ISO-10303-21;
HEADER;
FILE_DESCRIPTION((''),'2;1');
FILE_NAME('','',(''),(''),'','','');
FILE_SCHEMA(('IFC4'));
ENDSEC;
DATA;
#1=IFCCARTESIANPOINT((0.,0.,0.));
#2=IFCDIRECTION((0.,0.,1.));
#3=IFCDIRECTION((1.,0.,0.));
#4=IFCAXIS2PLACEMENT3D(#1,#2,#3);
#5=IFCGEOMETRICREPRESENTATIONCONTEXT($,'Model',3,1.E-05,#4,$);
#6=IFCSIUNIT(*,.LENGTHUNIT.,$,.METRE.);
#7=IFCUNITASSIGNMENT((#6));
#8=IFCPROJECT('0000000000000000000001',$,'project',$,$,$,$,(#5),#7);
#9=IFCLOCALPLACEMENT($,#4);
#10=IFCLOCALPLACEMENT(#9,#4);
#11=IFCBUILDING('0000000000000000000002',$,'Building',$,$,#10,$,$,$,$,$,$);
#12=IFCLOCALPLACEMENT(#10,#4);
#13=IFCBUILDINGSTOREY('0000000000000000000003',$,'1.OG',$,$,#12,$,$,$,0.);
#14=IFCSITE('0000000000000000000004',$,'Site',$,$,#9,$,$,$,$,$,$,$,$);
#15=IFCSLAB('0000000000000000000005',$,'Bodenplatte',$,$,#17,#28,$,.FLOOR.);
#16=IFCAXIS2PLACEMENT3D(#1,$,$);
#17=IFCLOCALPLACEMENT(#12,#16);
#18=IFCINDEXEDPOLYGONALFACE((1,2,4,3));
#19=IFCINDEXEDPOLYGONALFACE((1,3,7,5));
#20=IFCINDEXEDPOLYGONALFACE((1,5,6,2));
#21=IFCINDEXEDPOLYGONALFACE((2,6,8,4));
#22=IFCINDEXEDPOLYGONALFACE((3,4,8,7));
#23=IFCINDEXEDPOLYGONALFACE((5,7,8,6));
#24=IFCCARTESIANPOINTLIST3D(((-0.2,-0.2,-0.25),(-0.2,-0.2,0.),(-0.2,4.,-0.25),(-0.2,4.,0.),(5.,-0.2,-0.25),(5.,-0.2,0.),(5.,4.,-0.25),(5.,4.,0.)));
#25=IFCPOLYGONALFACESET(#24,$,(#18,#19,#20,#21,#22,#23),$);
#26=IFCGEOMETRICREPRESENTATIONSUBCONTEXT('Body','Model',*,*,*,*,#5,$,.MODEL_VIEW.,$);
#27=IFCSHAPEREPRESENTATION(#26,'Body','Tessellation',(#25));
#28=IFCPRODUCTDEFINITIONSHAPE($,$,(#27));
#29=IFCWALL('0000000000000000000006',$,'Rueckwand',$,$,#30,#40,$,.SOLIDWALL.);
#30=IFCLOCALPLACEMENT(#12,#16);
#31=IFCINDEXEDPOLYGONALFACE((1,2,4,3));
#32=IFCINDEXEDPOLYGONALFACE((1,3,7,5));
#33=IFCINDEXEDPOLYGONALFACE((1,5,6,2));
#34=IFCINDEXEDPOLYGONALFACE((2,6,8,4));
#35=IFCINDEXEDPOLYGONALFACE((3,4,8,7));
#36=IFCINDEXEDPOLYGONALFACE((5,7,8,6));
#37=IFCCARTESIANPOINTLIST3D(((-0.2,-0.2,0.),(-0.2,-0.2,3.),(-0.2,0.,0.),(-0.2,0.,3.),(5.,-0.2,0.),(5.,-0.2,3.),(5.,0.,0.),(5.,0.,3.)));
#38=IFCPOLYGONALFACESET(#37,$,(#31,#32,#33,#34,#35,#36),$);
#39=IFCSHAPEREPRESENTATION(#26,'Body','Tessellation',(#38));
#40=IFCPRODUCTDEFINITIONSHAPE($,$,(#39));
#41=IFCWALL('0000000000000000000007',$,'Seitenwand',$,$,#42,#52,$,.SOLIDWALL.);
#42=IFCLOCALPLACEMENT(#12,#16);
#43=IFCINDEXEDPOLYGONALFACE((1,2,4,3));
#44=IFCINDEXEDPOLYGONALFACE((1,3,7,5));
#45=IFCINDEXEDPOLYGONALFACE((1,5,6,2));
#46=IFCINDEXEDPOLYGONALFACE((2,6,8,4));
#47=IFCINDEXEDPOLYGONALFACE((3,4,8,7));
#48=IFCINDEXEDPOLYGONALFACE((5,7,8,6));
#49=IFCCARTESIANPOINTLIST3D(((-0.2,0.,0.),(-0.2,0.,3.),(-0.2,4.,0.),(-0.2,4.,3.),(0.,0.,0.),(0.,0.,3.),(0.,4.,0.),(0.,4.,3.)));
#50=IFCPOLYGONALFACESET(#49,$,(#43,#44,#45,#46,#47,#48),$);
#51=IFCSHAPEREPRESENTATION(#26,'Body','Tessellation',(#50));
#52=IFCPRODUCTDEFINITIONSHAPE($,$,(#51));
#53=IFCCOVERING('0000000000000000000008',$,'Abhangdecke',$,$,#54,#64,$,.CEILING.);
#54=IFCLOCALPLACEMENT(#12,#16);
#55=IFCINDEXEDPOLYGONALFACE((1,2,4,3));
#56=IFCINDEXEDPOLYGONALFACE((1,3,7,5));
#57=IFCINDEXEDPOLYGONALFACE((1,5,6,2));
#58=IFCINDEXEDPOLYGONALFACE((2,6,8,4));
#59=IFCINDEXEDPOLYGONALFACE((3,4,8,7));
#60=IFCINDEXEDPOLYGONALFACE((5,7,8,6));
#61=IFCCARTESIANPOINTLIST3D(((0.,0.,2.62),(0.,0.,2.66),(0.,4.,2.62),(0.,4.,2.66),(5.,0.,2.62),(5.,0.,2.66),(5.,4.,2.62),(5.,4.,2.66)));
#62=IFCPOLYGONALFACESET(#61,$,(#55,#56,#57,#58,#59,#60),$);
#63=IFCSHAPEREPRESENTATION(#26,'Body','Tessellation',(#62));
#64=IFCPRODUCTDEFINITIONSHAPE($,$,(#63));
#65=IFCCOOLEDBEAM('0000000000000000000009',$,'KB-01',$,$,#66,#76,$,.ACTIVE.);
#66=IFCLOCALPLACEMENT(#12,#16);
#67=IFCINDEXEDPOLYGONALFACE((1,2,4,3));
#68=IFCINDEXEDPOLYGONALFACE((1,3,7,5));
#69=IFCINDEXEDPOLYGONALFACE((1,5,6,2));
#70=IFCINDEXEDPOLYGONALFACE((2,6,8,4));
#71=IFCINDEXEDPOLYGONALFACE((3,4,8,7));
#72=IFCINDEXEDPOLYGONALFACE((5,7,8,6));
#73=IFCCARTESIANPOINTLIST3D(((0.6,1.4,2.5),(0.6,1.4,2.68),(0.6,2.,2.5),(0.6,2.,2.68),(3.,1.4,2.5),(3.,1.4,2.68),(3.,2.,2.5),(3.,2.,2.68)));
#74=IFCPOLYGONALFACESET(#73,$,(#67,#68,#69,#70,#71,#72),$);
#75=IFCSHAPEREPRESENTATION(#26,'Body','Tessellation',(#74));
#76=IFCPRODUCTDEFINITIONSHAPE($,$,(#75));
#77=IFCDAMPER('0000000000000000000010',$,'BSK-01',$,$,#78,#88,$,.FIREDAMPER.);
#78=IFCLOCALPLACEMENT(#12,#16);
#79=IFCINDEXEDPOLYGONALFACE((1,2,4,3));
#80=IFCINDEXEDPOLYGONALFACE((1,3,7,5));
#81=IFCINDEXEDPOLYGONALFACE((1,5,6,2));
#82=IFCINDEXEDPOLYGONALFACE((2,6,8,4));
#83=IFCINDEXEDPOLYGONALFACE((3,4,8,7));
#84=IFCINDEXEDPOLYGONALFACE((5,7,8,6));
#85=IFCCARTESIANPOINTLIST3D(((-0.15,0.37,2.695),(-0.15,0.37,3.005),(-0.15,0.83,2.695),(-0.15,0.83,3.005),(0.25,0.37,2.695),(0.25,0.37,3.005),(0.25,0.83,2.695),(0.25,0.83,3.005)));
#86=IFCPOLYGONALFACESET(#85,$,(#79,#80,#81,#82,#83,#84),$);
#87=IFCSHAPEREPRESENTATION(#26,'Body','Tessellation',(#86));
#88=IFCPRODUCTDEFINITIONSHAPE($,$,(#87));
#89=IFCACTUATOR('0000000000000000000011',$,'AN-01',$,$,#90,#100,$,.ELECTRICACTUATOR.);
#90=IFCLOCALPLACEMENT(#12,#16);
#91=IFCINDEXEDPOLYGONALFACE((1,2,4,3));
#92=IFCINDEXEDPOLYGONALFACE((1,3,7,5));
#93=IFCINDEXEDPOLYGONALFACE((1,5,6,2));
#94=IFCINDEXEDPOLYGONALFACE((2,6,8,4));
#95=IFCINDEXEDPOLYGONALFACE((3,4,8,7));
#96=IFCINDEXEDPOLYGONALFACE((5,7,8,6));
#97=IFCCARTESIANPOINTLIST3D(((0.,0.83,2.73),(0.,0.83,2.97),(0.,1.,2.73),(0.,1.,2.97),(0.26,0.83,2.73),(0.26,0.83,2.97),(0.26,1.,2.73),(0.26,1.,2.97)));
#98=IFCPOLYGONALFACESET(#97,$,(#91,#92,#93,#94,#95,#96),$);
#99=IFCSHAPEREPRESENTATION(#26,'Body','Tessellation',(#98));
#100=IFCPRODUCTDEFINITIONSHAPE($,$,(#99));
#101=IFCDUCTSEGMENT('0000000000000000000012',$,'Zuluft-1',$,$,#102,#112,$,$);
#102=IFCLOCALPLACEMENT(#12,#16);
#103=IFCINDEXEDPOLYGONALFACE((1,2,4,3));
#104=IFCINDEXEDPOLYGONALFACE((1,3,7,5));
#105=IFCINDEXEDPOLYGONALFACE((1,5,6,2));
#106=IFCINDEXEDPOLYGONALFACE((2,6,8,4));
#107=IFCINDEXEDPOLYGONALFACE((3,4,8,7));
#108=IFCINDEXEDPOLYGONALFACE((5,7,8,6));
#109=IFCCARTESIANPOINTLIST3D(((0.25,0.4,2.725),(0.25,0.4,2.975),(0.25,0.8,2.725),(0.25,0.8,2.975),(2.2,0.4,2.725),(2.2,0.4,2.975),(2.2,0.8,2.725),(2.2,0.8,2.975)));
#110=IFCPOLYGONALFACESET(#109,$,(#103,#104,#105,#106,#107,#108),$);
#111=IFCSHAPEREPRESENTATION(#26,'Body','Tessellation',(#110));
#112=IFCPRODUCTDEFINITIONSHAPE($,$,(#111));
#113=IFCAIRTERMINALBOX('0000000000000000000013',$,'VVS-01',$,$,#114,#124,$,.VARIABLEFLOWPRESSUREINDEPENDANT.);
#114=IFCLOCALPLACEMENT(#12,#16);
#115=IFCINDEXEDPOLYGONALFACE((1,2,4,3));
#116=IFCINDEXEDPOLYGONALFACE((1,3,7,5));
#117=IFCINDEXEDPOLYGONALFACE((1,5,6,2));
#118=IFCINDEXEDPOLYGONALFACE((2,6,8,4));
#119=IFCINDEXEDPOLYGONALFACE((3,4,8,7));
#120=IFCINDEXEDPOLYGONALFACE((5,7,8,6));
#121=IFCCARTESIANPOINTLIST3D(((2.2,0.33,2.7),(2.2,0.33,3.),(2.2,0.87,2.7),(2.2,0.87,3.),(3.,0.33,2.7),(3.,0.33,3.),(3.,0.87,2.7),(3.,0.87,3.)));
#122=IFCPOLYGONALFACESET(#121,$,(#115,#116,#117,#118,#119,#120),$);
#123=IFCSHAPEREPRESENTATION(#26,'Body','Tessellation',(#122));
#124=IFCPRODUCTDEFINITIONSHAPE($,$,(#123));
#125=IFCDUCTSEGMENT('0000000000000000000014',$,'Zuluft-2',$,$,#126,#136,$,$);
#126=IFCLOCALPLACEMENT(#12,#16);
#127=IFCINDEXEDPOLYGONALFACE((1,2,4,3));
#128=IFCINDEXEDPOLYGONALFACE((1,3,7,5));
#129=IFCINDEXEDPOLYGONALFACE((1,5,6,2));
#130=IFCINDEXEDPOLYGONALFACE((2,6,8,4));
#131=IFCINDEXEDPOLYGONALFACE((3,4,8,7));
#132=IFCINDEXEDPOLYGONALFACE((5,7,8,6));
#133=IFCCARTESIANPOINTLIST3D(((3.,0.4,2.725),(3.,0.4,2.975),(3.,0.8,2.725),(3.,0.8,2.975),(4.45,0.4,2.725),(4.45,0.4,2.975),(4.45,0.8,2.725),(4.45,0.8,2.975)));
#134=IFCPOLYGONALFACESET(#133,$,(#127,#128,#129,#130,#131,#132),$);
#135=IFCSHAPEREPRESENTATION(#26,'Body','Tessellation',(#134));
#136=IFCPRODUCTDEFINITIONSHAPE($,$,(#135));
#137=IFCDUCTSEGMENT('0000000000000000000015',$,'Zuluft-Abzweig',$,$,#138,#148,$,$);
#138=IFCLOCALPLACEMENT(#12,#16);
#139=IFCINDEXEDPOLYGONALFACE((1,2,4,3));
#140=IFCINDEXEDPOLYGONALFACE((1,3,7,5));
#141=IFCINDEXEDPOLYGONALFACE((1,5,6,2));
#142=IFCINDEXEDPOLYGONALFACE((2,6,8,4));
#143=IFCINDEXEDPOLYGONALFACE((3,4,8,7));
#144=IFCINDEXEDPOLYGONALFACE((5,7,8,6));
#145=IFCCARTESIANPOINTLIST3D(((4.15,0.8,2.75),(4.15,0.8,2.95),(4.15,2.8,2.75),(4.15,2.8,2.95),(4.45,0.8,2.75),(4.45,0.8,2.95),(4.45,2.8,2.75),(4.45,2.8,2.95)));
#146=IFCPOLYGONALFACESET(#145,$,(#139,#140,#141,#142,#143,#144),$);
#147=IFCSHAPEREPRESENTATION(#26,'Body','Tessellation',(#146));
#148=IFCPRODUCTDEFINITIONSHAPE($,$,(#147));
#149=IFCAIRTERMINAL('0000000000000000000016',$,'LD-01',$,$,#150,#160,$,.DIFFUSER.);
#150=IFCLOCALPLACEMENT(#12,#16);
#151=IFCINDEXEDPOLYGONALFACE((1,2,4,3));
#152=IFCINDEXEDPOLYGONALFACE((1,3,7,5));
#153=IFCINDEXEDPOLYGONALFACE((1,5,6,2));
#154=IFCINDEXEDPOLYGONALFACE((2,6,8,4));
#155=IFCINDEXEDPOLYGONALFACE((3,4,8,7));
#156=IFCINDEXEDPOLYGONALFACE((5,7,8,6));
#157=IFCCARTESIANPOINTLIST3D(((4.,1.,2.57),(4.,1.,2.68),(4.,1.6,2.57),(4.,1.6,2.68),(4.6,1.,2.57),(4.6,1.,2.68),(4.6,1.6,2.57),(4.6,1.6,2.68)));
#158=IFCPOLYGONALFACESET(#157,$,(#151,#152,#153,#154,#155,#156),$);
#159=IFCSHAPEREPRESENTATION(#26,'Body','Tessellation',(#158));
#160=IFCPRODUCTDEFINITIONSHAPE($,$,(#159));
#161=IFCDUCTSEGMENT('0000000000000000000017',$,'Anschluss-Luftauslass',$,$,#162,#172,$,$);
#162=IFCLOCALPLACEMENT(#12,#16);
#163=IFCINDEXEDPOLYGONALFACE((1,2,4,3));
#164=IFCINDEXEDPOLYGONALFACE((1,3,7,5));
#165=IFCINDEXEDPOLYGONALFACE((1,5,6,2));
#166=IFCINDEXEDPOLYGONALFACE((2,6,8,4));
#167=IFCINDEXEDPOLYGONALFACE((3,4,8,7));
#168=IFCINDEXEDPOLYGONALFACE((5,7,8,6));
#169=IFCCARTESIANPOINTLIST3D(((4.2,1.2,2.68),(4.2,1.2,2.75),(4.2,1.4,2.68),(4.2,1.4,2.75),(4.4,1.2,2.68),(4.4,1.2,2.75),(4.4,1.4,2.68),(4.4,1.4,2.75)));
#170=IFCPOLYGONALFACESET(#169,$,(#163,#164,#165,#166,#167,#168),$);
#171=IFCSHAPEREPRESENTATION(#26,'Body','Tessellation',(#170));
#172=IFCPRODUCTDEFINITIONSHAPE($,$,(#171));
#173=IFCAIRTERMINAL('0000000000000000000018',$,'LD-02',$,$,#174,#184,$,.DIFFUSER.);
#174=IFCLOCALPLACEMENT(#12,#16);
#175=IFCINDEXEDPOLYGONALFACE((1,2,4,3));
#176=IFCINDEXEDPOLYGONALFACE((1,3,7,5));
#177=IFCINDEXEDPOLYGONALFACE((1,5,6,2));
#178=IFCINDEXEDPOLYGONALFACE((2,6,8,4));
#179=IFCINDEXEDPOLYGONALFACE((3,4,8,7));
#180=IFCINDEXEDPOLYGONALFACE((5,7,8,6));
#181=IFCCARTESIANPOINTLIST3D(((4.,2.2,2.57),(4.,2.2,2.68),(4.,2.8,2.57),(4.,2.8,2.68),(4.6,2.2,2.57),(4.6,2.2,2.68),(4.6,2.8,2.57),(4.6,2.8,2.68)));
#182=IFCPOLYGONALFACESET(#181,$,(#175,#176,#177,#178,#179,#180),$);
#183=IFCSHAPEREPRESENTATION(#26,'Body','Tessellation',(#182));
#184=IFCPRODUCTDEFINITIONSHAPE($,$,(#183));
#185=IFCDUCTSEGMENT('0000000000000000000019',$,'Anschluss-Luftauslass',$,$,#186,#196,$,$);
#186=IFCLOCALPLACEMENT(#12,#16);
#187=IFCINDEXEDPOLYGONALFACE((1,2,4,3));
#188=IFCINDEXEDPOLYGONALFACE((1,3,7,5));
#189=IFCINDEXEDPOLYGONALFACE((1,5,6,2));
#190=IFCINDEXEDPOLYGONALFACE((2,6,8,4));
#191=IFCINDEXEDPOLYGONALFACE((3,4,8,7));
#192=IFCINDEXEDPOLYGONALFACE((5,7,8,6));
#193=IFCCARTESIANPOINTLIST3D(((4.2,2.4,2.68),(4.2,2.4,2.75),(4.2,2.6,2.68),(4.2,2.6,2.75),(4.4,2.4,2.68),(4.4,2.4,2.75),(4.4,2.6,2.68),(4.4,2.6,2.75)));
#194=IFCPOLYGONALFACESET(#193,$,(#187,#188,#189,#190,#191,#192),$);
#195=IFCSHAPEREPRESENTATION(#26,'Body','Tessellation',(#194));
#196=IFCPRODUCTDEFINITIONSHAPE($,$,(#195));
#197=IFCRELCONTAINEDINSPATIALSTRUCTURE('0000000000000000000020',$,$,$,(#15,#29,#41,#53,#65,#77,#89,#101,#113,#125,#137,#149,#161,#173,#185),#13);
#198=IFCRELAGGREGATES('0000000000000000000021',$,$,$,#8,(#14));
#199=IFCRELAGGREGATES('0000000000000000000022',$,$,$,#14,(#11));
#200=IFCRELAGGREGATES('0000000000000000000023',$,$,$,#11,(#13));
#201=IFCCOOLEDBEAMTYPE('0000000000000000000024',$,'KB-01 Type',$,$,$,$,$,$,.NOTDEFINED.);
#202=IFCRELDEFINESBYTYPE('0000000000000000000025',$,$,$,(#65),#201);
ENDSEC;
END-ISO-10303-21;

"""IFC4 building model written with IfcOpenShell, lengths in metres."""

from ifc_helpers import new_model, si_unit, frame, origin_with_axes, place, context, subcontext, project, spatial, polyline, outline, extrude, type_object, element, save


model = new_model("IFC4")

# Units and contexts
model_context = context("Model", 3, precision=1e-05, world=origin_with_axes())
body_context = subcontext(model_context, "Body", "Model", "MODEL_VIEW")
ifc_project = project(units=[si_unit("LENGTHUNIT", "METRE")], contexts=[model_context])

# Site, building, storey
site_placement = place(None, origin_with_axes())
site = spatial("IfcSite", under=ifc_project, at=site_placement, Name="Site")
building_placement = place(site_placement, origin_with_axes())
building = spatial("IfcBuilding", under=site, at=building_placement, Name="Building")
storey_placement = place(building_placement, origin_with_axes())
storey = spatial("IfcBuildingStorey", under=building, at=storey_placement, Name="1.OG", Elevation=0.0)

# Slab
slab_placement = place(storey_placement, frame((0.0, 0.0, -0.25), z_axis=(0.0, 0.0, 1.0), x_axis=(1.0, 0.0, 0.0)))
element("IfcSlab", 1, at=slab_placement, inside=storey, Name="Bodenplatte", PredefinedType="FLOOR", context=body_context, shape_type="SweptSolid", body=[
    extrude(outline(polyline([(-0.2, -0.2, 0.0), (5.0, -0.2, 0.0), (5.0, 4.0, 0.0), (-0.2, 4.0, 0.0), (-0.2, -0.2, 0.0)])), origin_with_axes(), (0.0, 0.0, 1.0), 0.25),
])

# Walls
wall_1_placement = place(storey_placement, frame((-0.2, -0.2, 0.0), z_axis=(0.0, 0.0, 1.0), x_axis=(1.0, 0.0, 0.0)))
element("IfcWall", 2, at=wall_1_placement, inside=storey, Name="Rueckwand", PredefinedType="SOLIDWALL", context=body_context, shape_type="SweptSolid", body=[
    extrude(outline(polyline([(0.0, 0.0, 0.0), (5.2, 0.0, 0.0), (5.2, 0.2, 0.0), (0.0, 0.2, 0.0), (0.0, 0.0, 0.0)])), origin_with_axes(), (0.0, 0.0, 1.0), 3.0),
])
wall_2_placement = place(storey_placement, frame((0.0, 0.0, 0.0), z_axis=(0.0, 0.0, 1.0), x_axis=(0.0, 1.0, 0.0)))
element("IfcWall", 3, at=wall_2_placement, inside=storey, Name="Seitenwand", PredefinedType="SOLIDWALL", context=body_context, shape_type="SweptSolid", body=[
    extrude(outline(polyline([(0.0, 0.0, 0.0), (4.0, 0.0, 0.0), (4.0, 0.2, 0.0), (0.0, 0.2, 0.0), (0.0, 0.0, 0.0)])), origin_with_axes(), (0.0, 0.0, 1.0), 3.0),
])

# Covering
covering_placement = place(storey_placement, frame((0.0, 0.0, 2.62), z_axis=(0.0, 0.0, 1.0), x_axis=(1.0, 0.0, 0.0)))
element("IfcCovering", 4, at=covering_placement, inside=storey, Name="Abhangdecke", PredefinedType="CEILING", context=body_context, shape_type="SweptSolid", body=[
    extrude(outline(polyline([(0.0, 0.0, 0.0), (5.0, 0.0, 0.0), (5.0, 4.0, 0.0), (0.0, 4.0, 0.0), (0.0, 0.0, 0.0)])), origin_with_axes(), (0.0, 0.0, 1.0), 0.04),
])

# Cooled beam
cooled_beam_type = type_object("IfcCooledBeamType", Name="KB-01 Type", PredefinedType="NOTDEFINED")
cooled_beam_placement = place(storey_placement, origin_with_axes())
element("IfcCooledBeam", 5, at=cooled_beam_placement, inside=storey, type_object=cooled_beam_type, Name="KB-01", PredefinedType="ACTIVE", context=body_context, shape_type="SweptSolid", body=[
    extrude(outline(polyline([(0.6, 1.4, 0.0), (3.0, 1.4, 0.0), (3.0, 2.0, 0.0), (0.6, 2.0, 0.0), (0.6, 1.4, 0.0)])), frame((0.0, 0.0, 2.5), z_axis=(0.0, 0.0, 1.0), x_axis=(1.0, 0.0, 0.0)), (0.0, 0.0, 1.0), 0.18),
])

# Damper
damper_placement = place(storey_placement, origin_with_axes())
element("IfcDamper", 6, at=damper_placement, inside=storey, Name="BSK-01", PredefinedType="FIREDAMPER", context=body_context, shape_type="SweptSolid", body=[
    extrude(outline(polyline([(-0.15, 0.37, 0.0), (0.25, 0.37, 0.0), (0.25, 0.83, 0.0), (-0.15, 0.83, 0.0), (-0.15, 0.37, 0.0)])), frame((0.0, 0.0, 2.695), z_axis=(0.0, 0.0, 1.0), x_axis=(1.0, 0.0, 0.0)), (0.0, 0.0, 1.0), 0.31),
])

# Actuator
actuator_placement = place(storey_placement, origin_with_axes())
element("IfcActuator", 7, at=actuator_placement, inside=storey, Name="AN-01", PredefinedType="ELECTRICACTUATOR", context=body_context, shape_type="SweptSolid", body=[
    extrude(outline(polyline([(0.0, 0.83, 0.0), (0.26, 0.83, 0.0), (0.26, 1.0, 0.0), (0.0, 1.0, 0.0), (0.0, 0.83, 0.0)])), frame((0.0, 0.0, 2.73), z_axis=(0.0, 0.0, 1.0), x_axis=(1.0, 0.0, 0.0)), (0.0, 0.0, 1.0), 0.24),
])

# Duct segment
duct_segment_1_placement = place(storey_placement, origin_with_axes())
element("IfcDuctSegment", 8, at=duct_segment_1_placement, inside=storey, Name="Zuluft-1", context=body_context, shape_type="SweptSolid", body=[
    extrude(outline(polyline([(-0.2, -0.125, 0.0), (0.2, -0.125, 0.0), (0.2, 0.125, 0.0), (-0.2, 0.125, 0.0), (-0.2, -0.125, 0.0)])), frame((0.25, 0.6, 2.85), z_axis=(1.0, 0.0, 0.0), x_axis=(0.0, 1.0, 0.0)), (0.0, 0.0, 1.0), 1.95),
])

# Air terminal box
air_terminal_box_placement = place(storey_placement, origin_with_axes())
element("IfcAirTerminalBox", 9, at=air_terminal_box_placement, inside=storey, Name="VVS-01", PredefinedType="VARIABLEFLOWPRESSUREINDEPENDANT", context=body_context, shape_type="SweptSolid", body=[
    extrude(outline(polyline([(2.2, 0.33, 0.0), (3.0, 0.33, 0.0), (3.0, 0.87, 0.0), (2.2, 0.87, 0.0), (2.2, 0.33, 0.0)])), frame((0.0, 0.0, 2.7), z_axis=(0.0, 0.0, 1.0), x_axis=(1.0, 0.0, 0.0)), (0.0, 0.0, 1.0), 0.3),
])

# Duct segments
duct_segment_2_placement = place(storey_placement, origin_with_axes())
element("IfcDuctSegment", 10, at=duct_segment_2_placement, inside=storey, Name="Zuluft-2", context=body_context, shape_type="SweptSolid", body=[
    extrude(outline(polyline([(-0.2, -0.125, 0.0), (0.2, -0.125, 0.0), (0.2, 0.125, 0.0), (-0.2, 0.125, 0.0), (-0.2, -0.125, 0.0)])), frame((3.0, 0.6, 2.85), z_axis=(1.0, 0.0, 0.0), x_axis=(0.0, 1.0, 0.0)), (0.0, 0.0, 1.0), 1.45),
])
duct_segment_3_placement = place(storey_placement, origin_with_axes())
element("IfcDuctSegment", 11, at=duct_segment_3_placement, inside=storey, Name="Zuluft-Abzweig", context=body_context, shape_type="SweptSolid", body=[
    extrude(outline(polyline([(-0.15, -0.1, 0.0), (0.15, -0.1, 0.0), (0.15, 0.1, 0.0), (-0.15, 0.1, 0.0), (-0.15, -0.1, 0.0)])), frame((4.3, 0.8, 2.85), z_axis=(0.0, 1.0, 0.0), x_axis=(-1.0, 0.0, 0.0)), (0.0, 0.0, 1.0), 2.0),
])

# Air terminal
air_terminal_1_placement = place(storey_placement, origin_with_axes())
element("IfcAirTerminal", 12, at=air_terminal_1_placement, inside=storey, Name="LD-01", PredefinedType="DIFFUSER", context=body_context, shape_type="SweptSolid", body=[
    extrude(outline(polyline([(4.0, 1.0, 0.0), (4.6, 1.0, 0.0), (4.6, 1.6, 0.0), (4.0, 1.6, 0.0), (4.0, 1.0, 0.0)])), frame((0.0, 0.0, 2.57), z_axis=(0.0, 0.0, 1.0), x_axis=(1.0, 0.0, 0.0)), (0.0, 0.0, 1.0), 0.11),
])

# Duct segment
duct_segment_4_placement = place(storey_placement, origin_with_axes())
element("IfcDuctSegment", 13, at=duct_segment_4_placement, inside=storey, Name="Anschluss-Luftauslass", context=body_context, shape_type="SweptSolid", body=[
    extrude(outline(polyline([(-0.1, -0.1, 0.0), (0.1, -0.1, 0.0), (0.1, 0.1, 0.0), (-0.1, 0.1, 0.0), (-0.1, -0.1, 0.0)])), frame((4.3, 1.3, 2.68), z_axis=(0.0, 0.0, 1.0), x_axis=(1.0, 0.0, 0.0)), (0.0, 0.0, 1.0), 0.07),
])

# Air terminal
air_terminal_2_placement = place(storey_placement, origin_with_axes())
element("IfcAirTerminal", 14, at=air_terminal_2_placement, inside=storey, Name="LD-02", PredefinedType="DIFFUSER", context=body_context, shape_type="SweptSolid", body=[
    extrude(outline(polyline([(4.0, 2.2, 0.0), (4.6, 2.2, 0.0), (4.6, 2.8, 0.0), (4.0, 2.8, 0.0), (4.0, 2.2, 0.0)])), frame((0.0, 0.0, 2.57), z_axis=(0.0, 0.0, 1.0), x_axis=(1.0, 0.0, 0.0)), (0.0, 0.0, 1.0), 0.11),
])

# Duct segment
duct_segment_5_placement = place(storey_placement, origin_with_axes())
element("IfcDuctSegment", 15, at=duct_segment_5_placement, inside=storey, Name="Anschluss-Luftauslass", context=body_context, shape_type="SweptSolid", body=[
    extrude(outline(polyline([(-0.1, -0.1, 0.0), (0.1, -0.1, 0.0), (0.1, 0.1, 0.0), (-0.1, 0.1, 0.0), (-0.1, -0.1, 0.0)])), frame((4.3, 2.5, 2.68), z_axis=(0.0, 0.0, 1.0), x_axis=(1.0, 0.0, 0.0)), (0.0, 0.0, 1.0), 0.07),
])

save(model, "model.ifc")
